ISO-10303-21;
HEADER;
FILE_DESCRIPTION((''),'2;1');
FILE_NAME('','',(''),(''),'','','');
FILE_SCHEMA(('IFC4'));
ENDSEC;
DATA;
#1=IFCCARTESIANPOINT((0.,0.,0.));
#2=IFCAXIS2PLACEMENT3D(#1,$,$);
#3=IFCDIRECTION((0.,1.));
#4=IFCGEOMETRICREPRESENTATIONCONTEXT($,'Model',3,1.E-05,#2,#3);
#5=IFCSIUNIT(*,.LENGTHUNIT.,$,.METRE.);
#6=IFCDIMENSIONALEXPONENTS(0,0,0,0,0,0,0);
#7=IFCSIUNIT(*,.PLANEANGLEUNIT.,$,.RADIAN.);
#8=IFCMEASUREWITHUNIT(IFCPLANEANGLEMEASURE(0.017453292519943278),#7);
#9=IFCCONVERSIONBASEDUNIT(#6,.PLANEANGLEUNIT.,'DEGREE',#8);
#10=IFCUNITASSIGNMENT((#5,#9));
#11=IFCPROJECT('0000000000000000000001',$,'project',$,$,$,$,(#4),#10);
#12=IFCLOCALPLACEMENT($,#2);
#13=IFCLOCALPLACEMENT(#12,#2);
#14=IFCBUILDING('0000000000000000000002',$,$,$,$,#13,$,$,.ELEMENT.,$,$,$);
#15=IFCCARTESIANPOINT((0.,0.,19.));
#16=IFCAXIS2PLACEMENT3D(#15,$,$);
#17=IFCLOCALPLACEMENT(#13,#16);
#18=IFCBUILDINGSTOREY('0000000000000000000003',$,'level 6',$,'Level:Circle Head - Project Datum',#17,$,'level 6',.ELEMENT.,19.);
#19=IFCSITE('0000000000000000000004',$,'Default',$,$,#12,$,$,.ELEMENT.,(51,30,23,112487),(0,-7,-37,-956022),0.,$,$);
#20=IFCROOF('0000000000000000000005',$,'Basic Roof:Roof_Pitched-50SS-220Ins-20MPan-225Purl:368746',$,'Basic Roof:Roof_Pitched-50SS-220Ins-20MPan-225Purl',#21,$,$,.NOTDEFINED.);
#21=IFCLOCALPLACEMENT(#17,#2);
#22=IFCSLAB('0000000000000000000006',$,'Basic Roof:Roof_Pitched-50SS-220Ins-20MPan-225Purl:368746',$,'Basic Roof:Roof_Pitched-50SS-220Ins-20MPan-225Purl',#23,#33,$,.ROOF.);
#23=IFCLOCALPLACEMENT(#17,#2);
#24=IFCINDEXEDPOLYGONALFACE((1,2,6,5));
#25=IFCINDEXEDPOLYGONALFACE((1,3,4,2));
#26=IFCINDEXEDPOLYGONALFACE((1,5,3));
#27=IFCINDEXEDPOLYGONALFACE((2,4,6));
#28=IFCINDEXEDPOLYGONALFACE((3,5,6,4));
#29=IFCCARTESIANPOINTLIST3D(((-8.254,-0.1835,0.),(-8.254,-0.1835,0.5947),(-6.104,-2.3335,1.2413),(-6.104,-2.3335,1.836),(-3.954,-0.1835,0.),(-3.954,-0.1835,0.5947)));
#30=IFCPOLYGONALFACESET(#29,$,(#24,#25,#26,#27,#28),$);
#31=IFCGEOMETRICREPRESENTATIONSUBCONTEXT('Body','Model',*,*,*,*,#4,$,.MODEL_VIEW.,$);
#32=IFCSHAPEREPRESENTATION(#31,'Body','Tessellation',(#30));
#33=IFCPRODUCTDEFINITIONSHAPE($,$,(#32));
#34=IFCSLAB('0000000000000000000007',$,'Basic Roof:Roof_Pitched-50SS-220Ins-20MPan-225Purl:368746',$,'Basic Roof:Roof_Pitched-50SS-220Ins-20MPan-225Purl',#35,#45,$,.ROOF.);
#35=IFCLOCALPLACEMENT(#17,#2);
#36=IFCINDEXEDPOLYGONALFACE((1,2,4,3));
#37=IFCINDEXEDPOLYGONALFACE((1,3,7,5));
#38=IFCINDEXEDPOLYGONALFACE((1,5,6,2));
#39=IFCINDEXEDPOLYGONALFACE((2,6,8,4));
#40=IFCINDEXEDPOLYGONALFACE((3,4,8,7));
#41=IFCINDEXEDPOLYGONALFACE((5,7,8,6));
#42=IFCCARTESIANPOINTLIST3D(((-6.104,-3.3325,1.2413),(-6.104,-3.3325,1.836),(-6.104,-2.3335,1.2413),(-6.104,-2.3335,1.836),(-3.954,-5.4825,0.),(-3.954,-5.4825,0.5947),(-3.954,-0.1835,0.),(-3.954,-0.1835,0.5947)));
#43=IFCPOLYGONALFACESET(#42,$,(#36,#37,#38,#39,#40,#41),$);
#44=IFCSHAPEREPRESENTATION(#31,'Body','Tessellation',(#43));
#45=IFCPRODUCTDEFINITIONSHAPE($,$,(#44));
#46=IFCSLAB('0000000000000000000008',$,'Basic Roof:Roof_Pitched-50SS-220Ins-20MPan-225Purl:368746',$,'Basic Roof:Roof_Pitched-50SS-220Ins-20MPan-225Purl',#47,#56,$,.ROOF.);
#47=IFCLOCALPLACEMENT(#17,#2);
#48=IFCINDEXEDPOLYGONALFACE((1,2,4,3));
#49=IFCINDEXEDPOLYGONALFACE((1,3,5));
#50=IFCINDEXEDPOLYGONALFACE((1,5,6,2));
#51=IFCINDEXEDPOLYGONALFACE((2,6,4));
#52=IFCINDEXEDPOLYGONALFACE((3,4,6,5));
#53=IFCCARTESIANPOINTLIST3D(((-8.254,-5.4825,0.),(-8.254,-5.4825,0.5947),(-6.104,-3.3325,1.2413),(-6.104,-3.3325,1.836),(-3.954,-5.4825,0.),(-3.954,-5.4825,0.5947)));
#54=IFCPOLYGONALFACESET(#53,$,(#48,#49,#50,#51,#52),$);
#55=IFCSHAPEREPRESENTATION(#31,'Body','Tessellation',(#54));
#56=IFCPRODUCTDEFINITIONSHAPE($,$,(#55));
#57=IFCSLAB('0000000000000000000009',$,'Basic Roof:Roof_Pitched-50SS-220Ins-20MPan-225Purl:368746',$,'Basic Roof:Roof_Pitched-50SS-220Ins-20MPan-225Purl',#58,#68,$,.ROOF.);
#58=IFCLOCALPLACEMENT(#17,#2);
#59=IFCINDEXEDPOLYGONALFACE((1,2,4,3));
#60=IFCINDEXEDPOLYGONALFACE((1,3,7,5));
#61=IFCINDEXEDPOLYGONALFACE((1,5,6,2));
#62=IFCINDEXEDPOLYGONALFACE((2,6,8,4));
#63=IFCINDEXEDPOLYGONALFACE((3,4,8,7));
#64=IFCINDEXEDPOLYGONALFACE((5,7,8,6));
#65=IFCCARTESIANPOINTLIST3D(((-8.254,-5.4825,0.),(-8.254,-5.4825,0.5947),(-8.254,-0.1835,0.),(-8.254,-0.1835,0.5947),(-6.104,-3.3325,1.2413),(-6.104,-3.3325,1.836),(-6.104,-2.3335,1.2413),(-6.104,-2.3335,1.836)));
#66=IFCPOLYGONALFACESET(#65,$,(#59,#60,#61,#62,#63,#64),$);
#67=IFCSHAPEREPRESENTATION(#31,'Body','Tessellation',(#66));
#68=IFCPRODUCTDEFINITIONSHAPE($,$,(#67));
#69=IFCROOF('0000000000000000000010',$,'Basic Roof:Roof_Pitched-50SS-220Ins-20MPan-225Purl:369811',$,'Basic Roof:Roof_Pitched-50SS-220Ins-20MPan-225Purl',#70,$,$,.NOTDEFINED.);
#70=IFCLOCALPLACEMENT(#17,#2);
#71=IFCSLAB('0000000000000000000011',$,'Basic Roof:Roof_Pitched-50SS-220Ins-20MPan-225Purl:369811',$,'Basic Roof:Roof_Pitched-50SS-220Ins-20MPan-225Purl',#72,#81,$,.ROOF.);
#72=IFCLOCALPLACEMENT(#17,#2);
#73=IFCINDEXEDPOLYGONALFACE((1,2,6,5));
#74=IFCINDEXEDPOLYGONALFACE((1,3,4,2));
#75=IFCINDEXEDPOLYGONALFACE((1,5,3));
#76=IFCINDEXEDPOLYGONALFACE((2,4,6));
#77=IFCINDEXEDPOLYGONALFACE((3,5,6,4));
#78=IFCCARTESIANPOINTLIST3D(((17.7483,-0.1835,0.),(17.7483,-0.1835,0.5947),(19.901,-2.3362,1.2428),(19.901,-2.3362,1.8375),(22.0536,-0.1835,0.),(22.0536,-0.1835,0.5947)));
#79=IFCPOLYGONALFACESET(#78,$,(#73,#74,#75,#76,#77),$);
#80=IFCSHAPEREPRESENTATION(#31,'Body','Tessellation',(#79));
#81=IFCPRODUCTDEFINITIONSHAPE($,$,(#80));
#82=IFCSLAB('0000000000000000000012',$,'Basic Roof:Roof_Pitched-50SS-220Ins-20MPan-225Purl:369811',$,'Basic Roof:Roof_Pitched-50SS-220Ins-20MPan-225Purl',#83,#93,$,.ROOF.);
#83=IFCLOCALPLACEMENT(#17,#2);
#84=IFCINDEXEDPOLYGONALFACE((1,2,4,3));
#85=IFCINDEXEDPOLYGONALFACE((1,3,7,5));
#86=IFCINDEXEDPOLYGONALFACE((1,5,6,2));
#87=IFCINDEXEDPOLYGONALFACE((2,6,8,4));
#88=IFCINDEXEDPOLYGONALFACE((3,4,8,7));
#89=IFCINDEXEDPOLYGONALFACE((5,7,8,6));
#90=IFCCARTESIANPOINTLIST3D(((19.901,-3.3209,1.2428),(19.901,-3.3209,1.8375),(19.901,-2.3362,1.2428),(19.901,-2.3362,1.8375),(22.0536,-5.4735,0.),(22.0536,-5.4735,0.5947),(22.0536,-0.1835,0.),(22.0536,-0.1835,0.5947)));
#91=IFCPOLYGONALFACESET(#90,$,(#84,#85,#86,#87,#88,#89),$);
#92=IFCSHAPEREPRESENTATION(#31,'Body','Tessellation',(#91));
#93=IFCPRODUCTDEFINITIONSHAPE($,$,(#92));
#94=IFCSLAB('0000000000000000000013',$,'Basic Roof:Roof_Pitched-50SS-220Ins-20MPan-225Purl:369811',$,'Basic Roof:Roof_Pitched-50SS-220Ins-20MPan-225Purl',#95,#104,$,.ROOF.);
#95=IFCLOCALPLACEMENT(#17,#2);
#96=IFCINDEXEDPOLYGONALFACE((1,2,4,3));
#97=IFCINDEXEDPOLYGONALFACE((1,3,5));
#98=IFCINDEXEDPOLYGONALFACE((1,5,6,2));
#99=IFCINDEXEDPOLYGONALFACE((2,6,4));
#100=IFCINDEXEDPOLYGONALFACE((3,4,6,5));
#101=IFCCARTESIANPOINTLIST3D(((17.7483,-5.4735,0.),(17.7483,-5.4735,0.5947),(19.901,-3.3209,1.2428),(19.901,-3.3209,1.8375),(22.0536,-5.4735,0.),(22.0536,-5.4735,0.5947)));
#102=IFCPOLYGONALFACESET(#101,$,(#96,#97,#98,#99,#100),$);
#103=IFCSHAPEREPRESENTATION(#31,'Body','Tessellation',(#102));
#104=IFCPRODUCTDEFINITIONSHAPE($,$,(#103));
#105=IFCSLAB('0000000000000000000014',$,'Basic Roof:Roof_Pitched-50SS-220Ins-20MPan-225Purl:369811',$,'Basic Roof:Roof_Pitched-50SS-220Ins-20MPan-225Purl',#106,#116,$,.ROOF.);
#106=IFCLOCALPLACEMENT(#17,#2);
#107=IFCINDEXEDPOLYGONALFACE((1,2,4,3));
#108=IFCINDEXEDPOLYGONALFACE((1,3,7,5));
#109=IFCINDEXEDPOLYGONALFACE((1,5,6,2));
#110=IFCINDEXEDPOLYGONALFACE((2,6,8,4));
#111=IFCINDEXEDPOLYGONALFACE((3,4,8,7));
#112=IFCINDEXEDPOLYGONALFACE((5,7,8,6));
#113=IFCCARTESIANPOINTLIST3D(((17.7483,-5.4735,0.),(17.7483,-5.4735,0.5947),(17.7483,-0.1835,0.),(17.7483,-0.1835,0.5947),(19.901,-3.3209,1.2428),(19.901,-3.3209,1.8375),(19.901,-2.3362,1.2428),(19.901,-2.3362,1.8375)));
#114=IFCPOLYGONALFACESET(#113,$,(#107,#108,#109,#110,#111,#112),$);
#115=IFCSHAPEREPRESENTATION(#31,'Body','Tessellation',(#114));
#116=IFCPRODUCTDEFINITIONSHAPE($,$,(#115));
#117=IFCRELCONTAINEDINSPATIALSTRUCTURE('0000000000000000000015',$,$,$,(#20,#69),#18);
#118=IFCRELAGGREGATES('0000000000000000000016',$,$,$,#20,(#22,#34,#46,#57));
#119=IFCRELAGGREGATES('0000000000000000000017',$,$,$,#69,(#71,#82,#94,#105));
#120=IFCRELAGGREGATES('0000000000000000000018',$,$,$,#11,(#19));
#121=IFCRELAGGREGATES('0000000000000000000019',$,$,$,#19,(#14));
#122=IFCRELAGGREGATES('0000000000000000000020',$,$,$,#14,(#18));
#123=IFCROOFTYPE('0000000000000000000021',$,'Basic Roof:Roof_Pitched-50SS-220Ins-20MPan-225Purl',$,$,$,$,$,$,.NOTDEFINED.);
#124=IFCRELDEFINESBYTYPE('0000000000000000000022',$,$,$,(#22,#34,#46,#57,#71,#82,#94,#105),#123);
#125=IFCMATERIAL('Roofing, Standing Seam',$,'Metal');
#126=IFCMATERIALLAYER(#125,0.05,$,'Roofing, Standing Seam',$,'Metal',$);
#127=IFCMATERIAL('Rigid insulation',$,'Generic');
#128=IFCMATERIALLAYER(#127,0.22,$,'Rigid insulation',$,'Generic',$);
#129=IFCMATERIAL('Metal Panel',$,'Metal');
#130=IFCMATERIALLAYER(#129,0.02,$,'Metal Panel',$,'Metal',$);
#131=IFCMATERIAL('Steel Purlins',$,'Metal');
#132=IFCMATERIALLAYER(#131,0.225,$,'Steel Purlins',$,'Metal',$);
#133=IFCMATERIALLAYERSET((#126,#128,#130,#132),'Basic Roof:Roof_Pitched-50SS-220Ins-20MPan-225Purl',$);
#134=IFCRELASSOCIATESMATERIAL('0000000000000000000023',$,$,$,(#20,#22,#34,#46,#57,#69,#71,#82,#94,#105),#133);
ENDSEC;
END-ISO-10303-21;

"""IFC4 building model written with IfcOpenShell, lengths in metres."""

from ifc_helpers import new_model, entity, si_unit, converted_unit, direction, frame, origin, place, context, subcontext, project, spatial, polyline, outline, extrude, material, layer, layer_set, type_object, element, aggregate, save


model = new_model("IFC4")

# Units and contexts
model_context = context("Model", 3, precision=1e-05, world=origin(), true_north=direction((0.0, 1.0)))
body_context = subcontext(model_context, "Body", "Model", "MODEL_VIEW")
ifc_project = project(units=[si_unit("LENGTHUNIT", "METRE"), converted_unit("PLANEANGLEUNIT", "DEGREE", entity("IfcPlaneAngleMeasure", 0.017453292519943278), si_unit("PLANEANGLEUNIT", "RADIAN"), dimensions=[0, 0, 0, 0, 0, 0, 0])], contexts=[model_context])

# Site, building, storey
site_placement = place(None, origin())
site = spatial("IfcSite", under=ifc_project, at=site_placement, Name="Default", CompositionType="ELEMENT", RefLatitude=(51, 30, 23, 112487), RefLongitude=(0, -7, -37, -956022), RefElevation=0.0)
building_placement = place(site_placement, origin())
building = spatial("IfcBuilding", under=site, at=building_placement, CompositionType="ELEMENT")
storey_placement = place(building_placement, frame((0.0, 0.0, 19.0)))
storey = spatial("IfcBuildingStorey", under=building, at=storey_placement, Name="level 6", ObjectType="Level:Circle Head - Project Datum", LongName="level 6", CompositionType="ELEMENT", Elevation=19.0)

# Roofs, slabs
ifc_material_1 = material(Name="Roofing, Standing Seam", Category="Metal")
ifc_layer_1 = layer(ifc_material_1, 0.05, Name="Roofing, Standing Seam", Category="Metal")
ifc_material_2 = material(Name="Rigid insulation", Category="Generic")
ifc_layer_2 = layer(ifc_material_2, 0.22, Name="Rigid insulation", Category="Generic")
ifc_material_3 = material(Name="Metal Panel", Category="Metal")
ifc_layer_3 = layer(ifc_material_3, 0.02, Name="Metal Panel", Category="Metal")
ifc_material_4 = material(Name="Steel Purlins", Category="Metal")
ifc_layer_4 = layer(ifc_material_4, 0.225, Name="Steel Purlins", Category="Metal")
ifc_layer_set = layer_set([ifc_layer_1, ifc_layer_2, ifc_layer_3, ifc_layer_4], Name="Basic Roof:Roof_Pitched-50SS-220Ins-20MPan-225Purl")
roof_1_placement = place(storey_placement, frame((-8.254, -5.4825, 0.0)))
roof_1 = element("IfcRoof", 1, at=roof_1_placement, inside=storey, material=ifc_layer_set, Name="Basic Roof:Roof_Pitched-50SS-220Ins-20MPan-225Purl:368746", ObjectType="Basic Roof:Roof_Pitched-50SS-220Ins-20MPan-225Purl", PredefinedType="NOTDEFINED")
roof_type = type_object("IfcRoofType", Name="Basic Roof:Roof_Pitched-50SS-220Ins-20MPan-225Purl", PredefinedType="NOTDEFINED")
slab_1_placement = place(roof_1_placement, origin())
slab_1 = element("IfcSlab", 2, at=slab_1_placement, type_object=roof_type, material=ifc_layer_set, Name="Basic Roof:Roof_Pitched-50SS-220Ins-20MPan-225Purl:368746", ObjectType="Basic Roof:Roof_Pitched-50SS-220Ins-20MPan-225Purl", PredefinedType="ROOF", context=body_context, shape_type="SweptSolid", body=[
    extrude(outline(polyline([(2.15, 1.2413), (-2.15, 1.2413), (0.0, -1.2413), (2.15, 1.2413)])), frame((2.15, 4.224, 0.6207), z_axis=(0.0, 0.5, 0.866025), x_axis=(1.0, 0.0, 0.0)), (0.0, -0.5, 0.866025), 0.5947),
])
slab_2_placement = place(roof_1_placement, origin())
slab_2 = element("IfcSlab", 3, at=slab_2_placement, type_object=roof_type, material=ifc_layer_set, Name="Basic Roof:Roof_Pitched-50SS-220Ins-20MPan-225Purl:368746", ObjectType="Basic Roof:Roof_Pitched-50SS-220Ins-20MPan-225Purl", PredefinedType="ROOF", context=body_context, shape_type="SweptSolid", body=[
    extrude(outline(polyline([(-1.2413, 0.4995), (-1.2413, -0.4995), (1.2413, -2.6495), (1.2413, 2.6495), (-1.2413, 0.4995)])), frame((3.225, 2.6495, 0.6207), z_axis=(0.5, 0.0, 0.866025), x_axis=(0.866025, 0.0, -0.5)), (-0.5, 0.0, 0.866025), 0.5947),
])
slab_3_placement = place(roof_1_placement, origin())
slab_3 = element("IfcSlab", 4, at=slab_3_placement, type_object=roof_type, material=ifc_layer_set, Name="Basic Roof:Roof_Pitched-50SS-220Ins-20MPan-225Purl:368746", ObjectType="Basic Roof:Roof_Pitched-50SS-220Ins-20MPan-225Purl", PredefinedType="ROOF", context=body_context, shape_type="SweptSolid", body=[
    extrude(outline(polyline([(-2.15, -1.2413), (2.15, -1.2413), (0.0, 1.2413), (-2.15, -1.2413)])), frame((2.15, 1.075, 0.6207), z_axis=(0.0, -0.5, 0.866025), x_axis=(1.0, 0.0, 0.0)), (0.0, 0.5, 0.866025), 0.5947),
])
slab_4_placement = place(roof_1_placement, origin())
slab_4 = element("IfcSlab", 5, at=slab_4_placement, type_object=roof_type, material=ifc_layer_set, Name="Basic Roof:Roof_Pitched-50SS-220Ins-20MPan-225Purl:368746", ObjectType="Basic Roof:Roof_Pitched-50SS-220Ins-20MPan-225Purl", PredefinedType="ROOF", context=body_context, shape_type="SweptSolid", body=[
    extrude(outline(polyline([(-1.2413, 2.6495), (-1.2413, -2.6495), (1.2413, -0.4995), (1.2413, 0.4995), (-1.2413, 2.6495)])), frame((1.075, 2.6495, 0.6207), z_axis=(-0.5, 0.0, 0.866025), x_axis=(0.866025, 0.0, 0.5)), (0.5, 0.0, 0.866025), 0.5947),
])
aggregate(roof_1, [slab_1, slab_2, slab_3, slab_4])
roof_2_placement = place(storey_placement, frame((17.7483, -5.4735, 0.0)))
roof_2 = element("IfcRoof", 6, at=roof_2_placement, inside=storey, material=ifc_layer_set, Name="Basic Roof:Roof_Pitched-50SS-220Ins-20MPan-225Purl:369811", ObjectType="Basic Roof:Roof_Pitched-50SS-220Ins-20MPan-225Purl", PredefinedType="NOTDEFINED")
slab_5_placement = place(roof_2_placement, origin())
slab_5 = element("IfcSlab", 7, at=slab_5_placement, type_object=roof_type, material=ifc_layer_set, Name="Basic Roof:Roof_Pitched-50SS-220Ins-20MPan-225Purl:369811", ObjectType="Basic Roof:Roof_Pitched-50SS-220Ins-20MPan-225Purl", PredefinedType="ROOF", context=body_context, shape_type="SweptSolid", body=[
    extrude(outline(polyline([(2.1526, 1.2428), (-2.1526, 1.2428), (0.0, -1.2428), (2.1526, 1.2428)])), frame((2.1526, 4.2137, 0.6214), z_axis=(0.0, 0.5, 0.866025), x_axis=(1.0, 0.0, 0.0)), (0.0, -0.5, 0.866025), 0.5947),
])
slab_6_placement = place(roof_2_placement, origin())
slab_6 = element("IfcSlab", 8, at=slab_6_placement, type_object=roof_type, material=ifc_layer_set, Name="Basic Roof:Roof_Pitched-50SS-220Ins-20MPan-225Purl:369811", ObjectType="Basic Roof:Roof_Pitched-50SS-220Ins-20MPan-225Purl", PredefinedType="ROOF", context=body_context, shape_type="SweptSolid", body=[
    extrude(outline(polyline([(-1.2428, 0.4924), (-1.2428, -0.4923), (1.2428, -2.645), (1.2428, 2.645), (-1.2428, 0.4924)])), frame((3.229, 2.645, 0.6214), z_axis=(0.5, 0.0, 0.866025), x_axis=(0.866025, 0.0, -0.5)), (-0.5, 0.0, 0.866025), 0.5947),
])
slab_7_placement = place(roof_2_placement, origin())
slab_7 = element("IfcSlab", 9, at=slab_7_placement, type_object=roof_type, material=ifc_layer_set, Name="Basic Roof:Roof_Pitched-50SS-220Ins-20MPan-225Purl:369811", ObjectType="Basic Roof:Roof_Pitched-50SS-220Ins-20MPan-225Purl", PredefinedType="ROOF", context=body_context, shape_type="SweptSolid", body=[
    extrude(outline(polyline([(-2.1526, -1.2428), (2.1526, -1.2428), (0.0, 1.2428), (-2.1526, -1.2428)])), frame((2.1526, 1.0763, 0.6214), z_axis=(0.0, -0.5, 0.866025), x_axis=(1.0, 0.0, 0.0)), (0.0, 0.5, 0.866025), 0.5947),
])
slab_8_placement = place(roof_2_placement, origin())
slab_8 = element("IfcSlab", 10, at=slab_8_placement, type_object=roof_type, material=ifc_layer_set, Name="Basic Roof:Roof_Pitched-50SS-220Ins-20MPan-225Purl:369811", ObjectType="Basic Roof:Roof_Pitched-50SS-220Ins-20MPan-225Purl", PredefinedType="ROOF", context=body_context, shape_type="SweptSolid", body=[
    extrude(outline(polyline([(-1.2428, 2.645), (-1.2428, -2.645), (1.2428, -0.4924), (1.2428, 0.4923), (-1.2428, 2.645)])), frame((1.0763, 2.645, 0.6214), z_axis=(-0.5, 0.0, 0.866025), x_axis=(0.866025, 0.0, 0.5)), (0.5, 0.0, 0.866025), 0.5947),
])
aggregate(roof_2, [slab_5, slab_6, slab_7, slab_8])

save(model, "model.ifc")
